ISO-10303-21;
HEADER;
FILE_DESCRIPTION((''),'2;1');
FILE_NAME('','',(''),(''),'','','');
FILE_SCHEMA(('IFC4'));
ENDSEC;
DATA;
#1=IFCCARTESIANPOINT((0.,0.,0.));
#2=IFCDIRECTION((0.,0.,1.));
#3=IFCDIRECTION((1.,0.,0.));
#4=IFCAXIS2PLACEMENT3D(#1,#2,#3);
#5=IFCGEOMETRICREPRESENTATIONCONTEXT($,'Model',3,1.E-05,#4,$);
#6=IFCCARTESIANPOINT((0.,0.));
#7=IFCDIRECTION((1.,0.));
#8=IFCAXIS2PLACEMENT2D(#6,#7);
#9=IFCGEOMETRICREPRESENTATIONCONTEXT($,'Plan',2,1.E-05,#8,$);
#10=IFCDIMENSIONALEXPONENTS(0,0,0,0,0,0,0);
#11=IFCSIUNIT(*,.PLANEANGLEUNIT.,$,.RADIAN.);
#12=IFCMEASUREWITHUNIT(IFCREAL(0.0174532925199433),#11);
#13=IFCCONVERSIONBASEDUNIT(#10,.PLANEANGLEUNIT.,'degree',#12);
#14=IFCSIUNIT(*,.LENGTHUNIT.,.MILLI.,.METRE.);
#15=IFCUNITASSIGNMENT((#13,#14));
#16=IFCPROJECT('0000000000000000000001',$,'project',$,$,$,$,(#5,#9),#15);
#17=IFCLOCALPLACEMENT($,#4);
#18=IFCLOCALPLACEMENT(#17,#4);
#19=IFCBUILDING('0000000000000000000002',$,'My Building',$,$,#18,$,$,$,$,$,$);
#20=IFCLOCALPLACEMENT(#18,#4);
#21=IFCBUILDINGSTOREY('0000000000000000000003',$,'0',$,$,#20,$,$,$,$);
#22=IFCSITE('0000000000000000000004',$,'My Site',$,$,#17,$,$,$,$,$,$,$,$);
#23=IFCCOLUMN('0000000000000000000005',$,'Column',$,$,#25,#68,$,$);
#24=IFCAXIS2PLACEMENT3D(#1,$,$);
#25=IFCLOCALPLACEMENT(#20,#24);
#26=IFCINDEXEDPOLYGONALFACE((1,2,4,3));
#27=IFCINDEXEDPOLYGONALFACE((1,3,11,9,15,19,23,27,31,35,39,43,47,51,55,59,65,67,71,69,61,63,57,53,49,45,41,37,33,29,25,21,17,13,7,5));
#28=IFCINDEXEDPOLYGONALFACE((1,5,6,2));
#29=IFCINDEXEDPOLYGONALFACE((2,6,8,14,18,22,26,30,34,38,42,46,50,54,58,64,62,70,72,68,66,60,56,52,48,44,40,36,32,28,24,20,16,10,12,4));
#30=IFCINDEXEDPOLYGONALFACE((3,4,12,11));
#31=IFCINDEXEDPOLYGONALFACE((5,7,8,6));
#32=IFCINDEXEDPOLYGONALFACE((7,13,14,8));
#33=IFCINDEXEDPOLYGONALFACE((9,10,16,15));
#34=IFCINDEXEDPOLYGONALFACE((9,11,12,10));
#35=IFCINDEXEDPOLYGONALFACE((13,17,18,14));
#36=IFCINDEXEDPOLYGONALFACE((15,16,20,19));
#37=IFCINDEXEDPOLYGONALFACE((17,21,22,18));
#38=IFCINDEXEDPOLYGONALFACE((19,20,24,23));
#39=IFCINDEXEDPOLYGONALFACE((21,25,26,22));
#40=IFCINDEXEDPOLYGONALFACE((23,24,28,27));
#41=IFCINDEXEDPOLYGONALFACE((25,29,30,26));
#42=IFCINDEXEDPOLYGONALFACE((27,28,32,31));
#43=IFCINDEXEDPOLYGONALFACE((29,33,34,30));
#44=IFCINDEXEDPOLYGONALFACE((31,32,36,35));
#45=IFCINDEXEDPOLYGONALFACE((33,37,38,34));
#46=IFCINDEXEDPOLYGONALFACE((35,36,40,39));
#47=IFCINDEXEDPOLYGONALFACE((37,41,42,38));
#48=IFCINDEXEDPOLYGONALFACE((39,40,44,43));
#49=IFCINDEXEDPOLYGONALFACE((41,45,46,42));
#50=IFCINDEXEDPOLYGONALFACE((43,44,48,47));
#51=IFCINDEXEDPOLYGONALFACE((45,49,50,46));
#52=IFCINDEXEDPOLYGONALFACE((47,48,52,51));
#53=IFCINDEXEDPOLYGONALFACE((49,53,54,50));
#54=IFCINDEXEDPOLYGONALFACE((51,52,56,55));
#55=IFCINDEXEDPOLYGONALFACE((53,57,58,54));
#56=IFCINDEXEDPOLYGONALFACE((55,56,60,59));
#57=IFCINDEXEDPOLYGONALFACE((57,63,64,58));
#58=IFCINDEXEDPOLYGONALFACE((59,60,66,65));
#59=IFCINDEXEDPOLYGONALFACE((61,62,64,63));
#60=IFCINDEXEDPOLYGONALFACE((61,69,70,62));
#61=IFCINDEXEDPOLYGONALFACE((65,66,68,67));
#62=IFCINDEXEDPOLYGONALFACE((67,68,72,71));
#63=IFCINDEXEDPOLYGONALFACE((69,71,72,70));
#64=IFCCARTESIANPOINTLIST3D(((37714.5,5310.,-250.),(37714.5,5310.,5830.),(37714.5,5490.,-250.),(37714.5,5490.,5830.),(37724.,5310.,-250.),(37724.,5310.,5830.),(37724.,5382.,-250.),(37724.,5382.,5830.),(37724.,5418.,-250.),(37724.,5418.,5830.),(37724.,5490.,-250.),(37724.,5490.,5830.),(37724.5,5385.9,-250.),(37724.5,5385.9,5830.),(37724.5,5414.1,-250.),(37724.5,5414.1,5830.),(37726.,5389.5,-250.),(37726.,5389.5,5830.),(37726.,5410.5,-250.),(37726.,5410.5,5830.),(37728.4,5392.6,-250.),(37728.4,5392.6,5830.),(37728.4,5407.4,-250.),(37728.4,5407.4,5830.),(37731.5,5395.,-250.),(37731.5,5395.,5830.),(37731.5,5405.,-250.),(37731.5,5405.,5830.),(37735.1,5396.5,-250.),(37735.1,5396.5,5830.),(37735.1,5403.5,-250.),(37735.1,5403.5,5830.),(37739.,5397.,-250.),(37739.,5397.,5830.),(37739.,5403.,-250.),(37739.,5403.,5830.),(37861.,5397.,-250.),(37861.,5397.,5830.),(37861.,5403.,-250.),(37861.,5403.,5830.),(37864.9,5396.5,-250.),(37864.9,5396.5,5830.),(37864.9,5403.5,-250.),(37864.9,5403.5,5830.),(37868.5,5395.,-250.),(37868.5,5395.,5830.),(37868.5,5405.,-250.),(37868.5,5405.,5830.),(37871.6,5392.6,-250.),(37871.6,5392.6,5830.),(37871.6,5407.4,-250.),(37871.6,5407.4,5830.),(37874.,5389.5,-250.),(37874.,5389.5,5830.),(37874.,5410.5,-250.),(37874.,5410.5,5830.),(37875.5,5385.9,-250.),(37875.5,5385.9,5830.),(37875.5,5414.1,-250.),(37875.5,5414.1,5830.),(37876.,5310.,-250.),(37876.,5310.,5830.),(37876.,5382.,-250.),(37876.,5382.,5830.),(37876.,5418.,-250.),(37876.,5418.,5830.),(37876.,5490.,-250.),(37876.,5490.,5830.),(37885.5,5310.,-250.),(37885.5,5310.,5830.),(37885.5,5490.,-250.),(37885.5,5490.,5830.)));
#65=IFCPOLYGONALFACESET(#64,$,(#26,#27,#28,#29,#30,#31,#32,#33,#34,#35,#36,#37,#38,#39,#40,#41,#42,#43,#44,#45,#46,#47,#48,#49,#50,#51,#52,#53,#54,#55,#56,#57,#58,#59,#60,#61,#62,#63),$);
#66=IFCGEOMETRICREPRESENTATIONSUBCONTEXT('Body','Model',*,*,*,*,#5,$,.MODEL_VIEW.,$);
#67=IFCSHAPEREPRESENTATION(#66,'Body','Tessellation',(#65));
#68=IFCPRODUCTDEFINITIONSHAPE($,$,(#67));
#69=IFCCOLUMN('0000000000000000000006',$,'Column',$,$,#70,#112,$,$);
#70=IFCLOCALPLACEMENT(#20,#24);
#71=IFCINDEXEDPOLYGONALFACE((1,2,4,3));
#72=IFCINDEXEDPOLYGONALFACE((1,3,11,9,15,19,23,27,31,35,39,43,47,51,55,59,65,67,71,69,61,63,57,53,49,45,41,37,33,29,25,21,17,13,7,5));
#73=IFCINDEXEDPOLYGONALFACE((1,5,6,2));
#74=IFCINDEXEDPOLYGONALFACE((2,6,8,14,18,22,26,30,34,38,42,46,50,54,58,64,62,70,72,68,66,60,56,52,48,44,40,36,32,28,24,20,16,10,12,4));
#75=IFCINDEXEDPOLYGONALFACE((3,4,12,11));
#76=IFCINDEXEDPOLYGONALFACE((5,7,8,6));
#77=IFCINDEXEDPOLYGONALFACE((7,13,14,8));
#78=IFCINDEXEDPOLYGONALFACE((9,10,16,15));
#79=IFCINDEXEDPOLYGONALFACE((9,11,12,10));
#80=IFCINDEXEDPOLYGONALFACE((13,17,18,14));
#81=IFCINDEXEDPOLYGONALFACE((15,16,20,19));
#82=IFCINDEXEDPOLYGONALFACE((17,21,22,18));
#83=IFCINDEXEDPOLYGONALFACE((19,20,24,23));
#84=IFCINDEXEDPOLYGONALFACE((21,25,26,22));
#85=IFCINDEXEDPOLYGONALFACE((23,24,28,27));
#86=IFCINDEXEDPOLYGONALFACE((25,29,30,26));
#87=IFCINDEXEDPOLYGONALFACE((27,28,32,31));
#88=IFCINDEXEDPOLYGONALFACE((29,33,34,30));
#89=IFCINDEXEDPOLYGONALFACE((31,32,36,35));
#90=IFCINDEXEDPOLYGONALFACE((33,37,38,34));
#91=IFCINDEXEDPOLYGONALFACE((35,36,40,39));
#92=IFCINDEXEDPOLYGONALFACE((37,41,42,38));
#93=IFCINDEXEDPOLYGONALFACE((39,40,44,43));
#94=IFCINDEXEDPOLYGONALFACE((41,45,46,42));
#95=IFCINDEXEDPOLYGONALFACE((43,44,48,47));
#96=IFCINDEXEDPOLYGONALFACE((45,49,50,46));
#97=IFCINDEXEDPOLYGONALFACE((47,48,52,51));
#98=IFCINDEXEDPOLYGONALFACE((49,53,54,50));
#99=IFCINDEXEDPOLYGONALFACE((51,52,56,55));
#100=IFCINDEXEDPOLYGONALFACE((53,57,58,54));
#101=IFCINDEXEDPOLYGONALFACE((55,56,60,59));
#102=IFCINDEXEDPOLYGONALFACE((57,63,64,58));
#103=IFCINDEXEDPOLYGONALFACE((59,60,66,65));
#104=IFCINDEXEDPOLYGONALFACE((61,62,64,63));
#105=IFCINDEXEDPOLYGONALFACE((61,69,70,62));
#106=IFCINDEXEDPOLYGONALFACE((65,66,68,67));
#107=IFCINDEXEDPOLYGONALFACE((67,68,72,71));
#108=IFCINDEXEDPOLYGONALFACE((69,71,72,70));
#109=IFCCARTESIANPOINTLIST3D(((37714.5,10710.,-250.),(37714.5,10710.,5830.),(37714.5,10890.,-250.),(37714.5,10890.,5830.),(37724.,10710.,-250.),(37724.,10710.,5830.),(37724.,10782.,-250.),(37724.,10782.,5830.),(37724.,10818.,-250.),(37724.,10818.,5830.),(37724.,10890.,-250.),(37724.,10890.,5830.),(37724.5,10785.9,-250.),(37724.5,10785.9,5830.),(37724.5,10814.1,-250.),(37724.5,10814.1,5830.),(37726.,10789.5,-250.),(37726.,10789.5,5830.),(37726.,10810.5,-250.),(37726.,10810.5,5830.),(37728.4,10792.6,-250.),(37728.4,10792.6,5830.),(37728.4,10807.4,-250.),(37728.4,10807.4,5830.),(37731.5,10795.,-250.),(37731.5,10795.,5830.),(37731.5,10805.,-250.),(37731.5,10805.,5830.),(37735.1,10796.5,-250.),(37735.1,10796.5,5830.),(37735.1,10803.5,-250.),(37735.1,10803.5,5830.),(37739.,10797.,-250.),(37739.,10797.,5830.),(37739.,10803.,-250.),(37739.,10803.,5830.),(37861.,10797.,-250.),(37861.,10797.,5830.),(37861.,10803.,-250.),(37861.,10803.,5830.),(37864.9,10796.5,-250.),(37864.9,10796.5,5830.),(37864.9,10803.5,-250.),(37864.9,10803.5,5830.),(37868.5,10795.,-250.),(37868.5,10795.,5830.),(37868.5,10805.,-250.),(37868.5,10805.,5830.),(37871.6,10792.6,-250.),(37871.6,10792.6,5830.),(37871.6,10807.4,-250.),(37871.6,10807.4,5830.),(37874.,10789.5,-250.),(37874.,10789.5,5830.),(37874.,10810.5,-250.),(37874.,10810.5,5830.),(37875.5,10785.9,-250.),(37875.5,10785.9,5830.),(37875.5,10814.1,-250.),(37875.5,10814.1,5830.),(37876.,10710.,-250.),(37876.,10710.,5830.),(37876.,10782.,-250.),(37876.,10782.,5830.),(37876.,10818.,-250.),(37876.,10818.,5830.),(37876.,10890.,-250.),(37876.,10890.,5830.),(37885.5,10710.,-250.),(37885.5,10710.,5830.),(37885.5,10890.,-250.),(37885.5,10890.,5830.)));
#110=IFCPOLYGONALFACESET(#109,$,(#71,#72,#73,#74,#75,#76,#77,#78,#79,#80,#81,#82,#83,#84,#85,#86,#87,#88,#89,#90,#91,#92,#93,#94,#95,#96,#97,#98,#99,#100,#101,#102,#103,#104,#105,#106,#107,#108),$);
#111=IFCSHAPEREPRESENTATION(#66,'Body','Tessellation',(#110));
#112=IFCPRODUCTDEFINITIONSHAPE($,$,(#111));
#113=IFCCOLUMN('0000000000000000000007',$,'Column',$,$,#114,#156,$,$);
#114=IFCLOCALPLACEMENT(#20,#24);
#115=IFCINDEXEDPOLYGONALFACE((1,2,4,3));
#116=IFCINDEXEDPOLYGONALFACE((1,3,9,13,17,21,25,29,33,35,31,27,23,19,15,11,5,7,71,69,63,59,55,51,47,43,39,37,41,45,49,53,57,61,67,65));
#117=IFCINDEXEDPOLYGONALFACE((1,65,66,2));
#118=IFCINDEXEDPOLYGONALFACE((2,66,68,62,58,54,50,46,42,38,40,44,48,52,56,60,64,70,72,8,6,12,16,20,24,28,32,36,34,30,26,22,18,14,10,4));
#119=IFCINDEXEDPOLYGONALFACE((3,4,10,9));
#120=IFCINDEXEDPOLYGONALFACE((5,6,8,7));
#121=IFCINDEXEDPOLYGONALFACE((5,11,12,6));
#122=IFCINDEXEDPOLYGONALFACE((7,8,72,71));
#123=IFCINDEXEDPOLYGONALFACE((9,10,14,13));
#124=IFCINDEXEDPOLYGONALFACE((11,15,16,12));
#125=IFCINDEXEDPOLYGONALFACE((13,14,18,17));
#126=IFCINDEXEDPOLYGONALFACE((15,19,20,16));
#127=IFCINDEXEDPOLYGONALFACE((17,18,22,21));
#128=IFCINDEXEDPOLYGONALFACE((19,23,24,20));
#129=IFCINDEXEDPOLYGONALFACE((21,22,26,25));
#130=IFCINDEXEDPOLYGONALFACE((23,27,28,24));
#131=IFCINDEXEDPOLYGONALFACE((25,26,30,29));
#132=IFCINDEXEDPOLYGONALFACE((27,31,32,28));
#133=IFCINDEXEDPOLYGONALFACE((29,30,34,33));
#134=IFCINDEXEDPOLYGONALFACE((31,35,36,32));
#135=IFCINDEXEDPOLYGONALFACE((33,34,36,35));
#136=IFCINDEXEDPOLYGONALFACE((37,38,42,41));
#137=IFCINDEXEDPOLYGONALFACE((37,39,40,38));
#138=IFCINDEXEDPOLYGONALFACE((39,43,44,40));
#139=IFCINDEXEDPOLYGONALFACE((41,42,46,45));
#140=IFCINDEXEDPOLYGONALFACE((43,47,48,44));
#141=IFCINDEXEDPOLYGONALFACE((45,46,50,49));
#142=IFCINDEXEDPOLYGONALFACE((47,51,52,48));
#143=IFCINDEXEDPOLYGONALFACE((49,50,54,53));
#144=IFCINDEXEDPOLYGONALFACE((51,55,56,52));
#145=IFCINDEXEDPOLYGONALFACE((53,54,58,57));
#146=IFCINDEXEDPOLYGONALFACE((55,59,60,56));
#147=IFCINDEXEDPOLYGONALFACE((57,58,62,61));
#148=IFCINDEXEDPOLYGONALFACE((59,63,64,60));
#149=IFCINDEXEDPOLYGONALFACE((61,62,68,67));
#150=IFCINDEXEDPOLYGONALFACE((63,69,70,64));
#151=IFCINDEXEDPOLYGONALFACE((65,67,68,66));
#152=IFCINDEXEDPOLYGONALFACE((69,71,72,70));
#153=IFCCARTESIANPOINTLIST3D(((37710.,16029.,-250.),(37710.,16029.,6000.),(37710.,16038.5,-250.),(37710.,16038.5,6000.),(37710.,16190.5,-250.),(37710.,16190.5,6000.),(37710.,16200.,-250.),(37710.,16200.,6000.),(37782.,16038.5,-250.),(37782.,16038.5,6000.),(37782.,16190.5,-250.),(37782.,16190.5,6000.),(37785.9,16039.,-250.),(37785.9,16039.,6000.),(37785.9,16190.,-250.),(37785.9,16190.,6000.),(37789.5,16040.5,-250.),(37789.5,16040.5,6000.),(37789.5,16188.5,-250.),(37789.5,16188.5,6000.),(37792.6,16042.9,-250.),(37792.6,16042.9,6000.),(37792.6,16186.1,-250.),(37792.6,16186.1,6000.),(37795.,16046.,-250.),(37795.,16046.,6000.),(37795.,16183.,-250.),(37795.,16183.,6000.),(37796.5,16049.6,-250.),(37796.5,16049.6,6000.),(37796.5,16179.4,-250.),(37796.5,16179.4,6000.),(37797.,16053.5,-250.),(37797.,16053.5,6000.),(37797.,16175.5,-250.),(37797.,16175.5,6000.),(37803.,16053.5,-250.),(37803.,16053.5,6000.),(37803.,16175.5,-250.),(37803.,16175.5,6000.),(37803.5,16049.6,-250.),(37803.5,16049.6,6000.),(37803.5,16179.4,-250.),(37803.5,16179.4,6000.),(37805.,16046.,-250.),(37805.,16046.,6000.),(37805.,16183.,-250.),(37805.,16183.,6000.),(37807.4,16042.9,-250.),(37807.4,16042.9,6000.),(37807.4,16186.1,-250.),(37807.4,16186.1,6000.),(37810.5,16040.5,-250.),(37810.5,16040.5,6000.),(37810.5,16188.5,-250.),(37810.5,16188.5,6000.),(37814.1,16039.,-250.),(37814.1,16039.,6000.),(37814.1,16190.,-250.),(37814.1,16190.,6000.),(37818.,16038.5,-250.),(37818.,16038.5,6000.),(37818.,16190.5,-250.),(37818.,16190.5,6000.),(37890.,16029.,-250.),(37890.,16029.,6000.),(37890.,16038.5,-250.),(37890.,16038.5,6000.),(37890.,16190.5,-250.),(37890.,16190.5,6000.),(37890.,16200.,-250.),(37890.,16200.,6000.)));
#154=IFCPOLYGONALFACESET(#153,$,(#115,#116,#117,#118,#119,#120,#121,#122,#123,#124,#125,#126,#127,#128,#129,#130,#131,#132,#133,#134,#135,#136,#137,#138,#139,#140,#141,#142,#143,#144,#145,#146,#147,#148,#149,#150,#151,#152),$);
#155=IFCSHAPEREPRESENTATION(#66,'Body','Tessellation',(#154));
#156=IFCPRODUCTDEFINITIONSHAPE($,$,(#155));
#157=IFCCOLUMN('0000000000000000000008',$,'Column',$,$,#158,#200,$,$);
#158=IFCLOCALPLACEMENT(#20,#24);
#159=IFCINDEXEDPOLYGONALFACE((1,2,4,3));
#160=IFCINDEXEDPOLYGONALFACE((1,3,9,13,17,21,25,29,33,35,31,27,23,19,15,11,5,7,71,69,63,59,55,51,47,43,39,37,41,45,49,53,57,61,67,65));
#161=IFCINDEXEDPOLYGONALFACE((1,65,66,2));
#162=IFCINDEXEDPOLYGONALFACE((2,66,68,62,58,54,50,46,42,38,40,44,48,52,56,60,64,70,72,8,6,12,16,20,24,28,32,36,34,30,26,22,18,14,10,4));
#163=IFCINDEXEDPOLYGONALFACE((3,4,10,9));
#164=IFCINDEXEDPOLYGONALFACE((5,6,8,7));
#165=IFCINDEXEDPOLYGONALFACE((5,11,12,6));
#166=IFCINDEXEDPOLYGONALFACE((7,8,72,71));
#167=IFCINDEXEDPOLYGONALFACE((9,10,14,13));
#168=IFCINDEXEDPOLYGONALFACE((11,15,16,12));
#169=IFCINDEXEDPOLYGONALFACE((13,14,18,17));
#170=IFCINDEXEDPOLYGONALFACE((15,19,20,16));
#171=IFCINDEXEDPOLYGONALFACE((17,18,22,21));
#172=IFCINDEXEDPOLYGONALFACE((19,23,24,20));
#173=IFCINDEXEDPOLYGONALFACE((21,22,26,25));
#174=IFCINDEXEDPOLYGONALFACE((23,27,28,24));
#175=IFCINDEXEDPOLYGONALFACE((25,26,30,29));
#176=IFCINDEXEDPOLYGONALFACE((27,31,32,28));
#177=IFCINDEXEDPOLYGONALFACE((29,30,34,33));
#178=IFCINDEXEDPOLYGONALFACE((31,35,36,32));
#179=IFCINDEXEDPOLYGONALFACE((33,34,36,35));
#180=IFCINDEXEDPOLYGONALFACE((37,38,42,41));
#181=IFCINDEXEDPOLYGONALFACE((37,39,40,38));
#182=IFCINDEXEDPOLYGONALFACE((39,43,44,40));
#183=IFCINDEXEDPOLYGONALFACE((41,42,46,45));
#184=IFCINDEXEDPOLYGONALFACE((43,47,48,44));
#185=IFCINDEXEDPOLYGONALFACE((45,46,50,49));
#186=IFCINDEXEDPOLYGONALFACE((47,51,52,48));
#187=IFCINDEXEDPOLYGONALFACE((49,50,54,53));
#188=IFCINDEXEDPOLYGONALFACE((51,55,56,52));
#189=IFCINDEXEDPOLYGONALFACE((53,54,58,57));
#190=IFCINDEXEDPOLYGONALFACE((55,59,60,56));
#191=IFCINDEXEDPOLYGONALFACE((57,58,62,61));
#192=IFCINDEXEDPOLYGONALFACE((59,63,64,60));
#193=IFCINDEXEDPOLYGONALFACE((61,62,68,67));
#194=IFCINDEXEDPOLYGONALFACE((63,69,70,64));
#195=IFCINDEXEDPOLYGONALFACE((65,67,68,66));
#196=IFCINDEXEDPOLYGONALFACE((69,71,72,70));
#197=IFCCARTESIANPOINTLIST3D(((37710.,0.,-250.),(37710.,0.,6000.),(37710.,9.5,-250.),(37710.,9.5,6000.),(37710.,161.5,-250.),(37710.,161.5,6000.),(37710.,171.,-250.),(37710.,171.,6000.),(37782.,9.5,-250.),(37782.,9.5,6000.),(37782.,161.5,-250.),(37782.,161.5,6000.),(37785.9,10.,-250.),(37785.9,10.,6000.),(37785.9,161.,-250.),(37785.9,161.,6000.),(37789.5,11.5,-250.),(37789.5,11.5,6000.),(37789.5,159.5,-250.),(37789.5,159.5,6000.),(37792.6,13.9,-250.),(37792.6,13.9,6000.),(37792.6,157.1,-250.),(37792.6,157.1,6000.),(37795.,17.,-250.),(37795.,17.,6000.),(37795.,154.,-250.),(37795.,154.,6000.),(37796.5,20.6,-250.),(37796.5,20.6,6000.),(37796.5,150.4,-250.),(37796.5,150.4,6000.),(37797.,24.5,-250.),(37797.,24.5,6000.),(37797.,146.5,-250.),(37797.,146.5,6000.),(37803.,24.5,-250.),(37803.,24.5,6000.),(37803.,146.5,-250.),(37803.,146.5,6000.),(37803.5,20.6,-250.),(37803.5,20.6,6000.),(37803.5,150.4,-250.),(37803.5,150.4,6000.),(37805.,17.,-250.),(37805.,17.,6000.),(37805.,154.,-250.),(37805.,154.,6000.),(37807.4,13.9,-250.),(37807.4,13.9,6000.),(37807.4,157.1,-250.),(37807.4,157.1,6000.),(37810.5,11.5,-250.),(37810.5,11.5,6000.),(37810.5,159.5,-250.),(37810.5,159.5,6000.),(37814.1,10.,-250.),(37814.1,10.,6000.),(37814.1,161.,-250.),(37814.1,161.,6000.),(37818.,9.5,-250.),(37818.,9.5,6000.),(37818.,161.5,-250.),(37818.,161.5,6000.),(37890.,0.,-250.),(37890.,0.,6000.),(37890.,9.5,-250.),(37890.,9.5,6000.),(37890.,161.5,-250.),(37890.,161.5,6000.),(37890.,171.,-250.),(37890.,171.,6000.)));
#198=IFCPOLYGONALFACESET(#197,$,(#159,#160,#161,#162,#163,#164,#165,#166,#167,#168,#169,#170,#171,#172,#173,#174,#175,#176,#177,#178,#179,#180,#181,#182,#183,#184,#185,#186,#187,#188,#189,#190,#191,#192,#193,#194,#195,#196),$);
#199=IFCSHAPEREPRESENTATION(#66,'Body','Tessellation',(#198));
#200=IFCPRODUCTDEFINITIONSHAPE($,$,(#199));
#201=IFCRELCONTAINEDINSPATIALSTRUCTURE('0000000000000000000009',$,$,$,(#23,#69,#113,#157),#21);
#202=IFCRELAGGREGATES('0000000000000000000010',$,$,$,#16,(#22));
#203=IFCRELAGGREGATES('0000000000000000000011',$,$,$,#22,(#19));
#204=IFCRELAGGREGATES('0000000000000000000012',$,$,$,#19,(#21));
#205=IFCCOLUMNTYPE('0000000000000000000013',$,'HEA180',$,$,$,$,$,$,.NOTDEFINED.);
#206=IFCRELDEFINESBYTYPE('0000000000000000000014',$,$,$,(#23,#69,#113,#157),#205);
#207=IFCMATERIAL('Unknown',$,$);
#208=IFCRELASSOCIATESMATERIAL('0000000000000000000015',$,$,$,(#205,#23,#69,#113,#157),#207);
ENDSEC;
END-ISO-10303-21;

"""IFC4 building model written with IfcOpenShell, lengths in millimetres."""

from ifc_helpers import new_model, entity, si_unit, converted_unit, frame, origin_with_axes, origin_2d_with_axis, place, context, subcontext, project, spatial, i_section, extrude, material, material_profile, profile_set, profile_usage, type_object, element, save


model = new_model("IFC4")

# Units and contexts
model_context = context("Model", 3, precision=1e-05, world=origin_with_axes())
plan_context = context("Plan", 2, precision=1e-05, world=origin_2d_with_axis())
body_context = subcontext(model_context, "Body", "Model", "MODEL_VIEW")
ifc_project = project(units=[converted_unit("PLANEANGLEUNIT", "degree", entity("IfcReal", 0.0174532925199433), si_unit("PLANEANGLEUNIT", "RADIAN"), dimensions=[0, 0, 0, 0, 0, 0, 0]), si_unit("LENGTHUNIT", "METRE", prefix="MILLI")], contexts=[model_context, plan_context])

# Site, building, storey
site_placement = place(None, origin_with_axes())
site = spatial("IfcSite", under=ifc_project, at=site_placement, Name="My Site")
building_placement = place(site_placement, origin_with_axes())
building = spatial("IfcBuilding", under=site, at=building_placement, Name="My Building")
storey_placement = place(building_placement, origin_with_axes())
storey = spatial("IfcBuildingStorey", under=building, at=storey_placement, Name="0")

# Columns
ifc_material = material(Name="Unknown")
ifc_material_profile_1 = material_profile(ifc_material, i_section(OverallWidth=180.0, OverallDepth=171.0, WebThickness=6.0, FlangeThickness=9.5, FilletRadius=15.0))
ifc_profile_set_1 = profile_set([ifc_material_profile_1])
column_type = type_object("IfcColumnType", Name="HEA180", PredefinedType="NOTDEFINED", material=ifc_profile_set_1)
ifc_profile_usage_1 = profile_usage(ifc_profile_set_1, cardinal=10)
column_1_placement = place(storey_placement, frame((37800.0, 5400.0, -250.0), z_axis=(0.0, 0.0, 1.0), x_axis=(0.0, 1.0, 0.0)))
element("IfcColumn", 1, at=column_1_placement, inside=storey, type_object=column_type, material=ifc_profile_usage_1, Name="Column", context=body_context, shape_type="SweptSolid", body=[
    extrude(i_section(OverallWidth=180.0, OverallDepth=171.0, WebThickness=6.0, FlangeThickness=9.5, FilletRadius=15.0), origin_with_axes(), (0.0, 0.0, 1.0), 6080.0),
])
ifc_profile_usage_2 = profile_usage(ifc_profile_set_1, cardinal=10)
column_2_placement = place(storey_placement, frame((37800.0, 10800.0, -250.0), z_axis=(0.0, 0.0, 1.0), x_axis=(0.0, 1.0, 0.0)))
element("IfcColumn", 2, at=column_2_placement, inside=storey, type_object=column_type, material=ifc_profile_usage_2, Name="Column", context=body_context, shape_type="SweptSolid", body=[
    extrude(i_section(OverallWidth=180.0, OverallDepth=171.0, WebThickness=6.0, FlangeThickness=9.5, FilletRadius=15.0), origin_with_axes(), (0.0, 0.0, 1.0), 6080.0),
])
ifc_profile_usage_3 = profile_usage(ifc_profile_set_1, cardinal=8)
column_3_placement = place(storey_placement, frame((37800.0, 16200.0, -250.0), z_axis=(0.0, 0.0, 1.0), x_axis=(1.0, 0.0, 0.0)))
element("IfcColumn", 3, at=column_3_placement, inside=storey, type_object=column_type, material=ifc_profile_usage_3, Name="Column", context=body_context, shape_type="SweptSolid", body=[
    extrude(i_section(OverallWidth=180.0, OverallDepth=171.0, WebThickness=6.0, FlangeThickness=9.5, FilletRadius=15.0), frame((0.0, -85.5, 0.0), z_axis=(0.0, 0.0, 1.0), x_axis=(1.0, 0.0, 0.0)), (0.0, 0.0, 1.0), 6250.0),
])
ifc_profile_usage_4 = profile_usage(ifc_profile_set_1, cardinal=2)
column_4_placement = place(storey_placement, frame((37800.0, 0.0, -250.0), z_axis=(0.0, 0.0, 1.0), x_axis=(1.0, 0.0, 0.0)))
element("IfcColumn", 4, at=column_4_placement, inside=storey, type_object=column_type, material=ifc_profile_usage_4, Name="Column", context=body_context, shape_type="SweptSolid", body=[
    extrude(i_section(OverallWidth=180.0, OverallDepth=171.0, WebThickness=6.0, FlangeThickness=9.5, FilletRadius=15.0), frame((0.0, 85.5, 0.0), z_axis=(0.0, 0.0, 1.0), x_axis=(1.0, 0.0, 0.0)), (0.0, 0.0, 1.0), 6250.0),
])

save(model, "model.ifc")
